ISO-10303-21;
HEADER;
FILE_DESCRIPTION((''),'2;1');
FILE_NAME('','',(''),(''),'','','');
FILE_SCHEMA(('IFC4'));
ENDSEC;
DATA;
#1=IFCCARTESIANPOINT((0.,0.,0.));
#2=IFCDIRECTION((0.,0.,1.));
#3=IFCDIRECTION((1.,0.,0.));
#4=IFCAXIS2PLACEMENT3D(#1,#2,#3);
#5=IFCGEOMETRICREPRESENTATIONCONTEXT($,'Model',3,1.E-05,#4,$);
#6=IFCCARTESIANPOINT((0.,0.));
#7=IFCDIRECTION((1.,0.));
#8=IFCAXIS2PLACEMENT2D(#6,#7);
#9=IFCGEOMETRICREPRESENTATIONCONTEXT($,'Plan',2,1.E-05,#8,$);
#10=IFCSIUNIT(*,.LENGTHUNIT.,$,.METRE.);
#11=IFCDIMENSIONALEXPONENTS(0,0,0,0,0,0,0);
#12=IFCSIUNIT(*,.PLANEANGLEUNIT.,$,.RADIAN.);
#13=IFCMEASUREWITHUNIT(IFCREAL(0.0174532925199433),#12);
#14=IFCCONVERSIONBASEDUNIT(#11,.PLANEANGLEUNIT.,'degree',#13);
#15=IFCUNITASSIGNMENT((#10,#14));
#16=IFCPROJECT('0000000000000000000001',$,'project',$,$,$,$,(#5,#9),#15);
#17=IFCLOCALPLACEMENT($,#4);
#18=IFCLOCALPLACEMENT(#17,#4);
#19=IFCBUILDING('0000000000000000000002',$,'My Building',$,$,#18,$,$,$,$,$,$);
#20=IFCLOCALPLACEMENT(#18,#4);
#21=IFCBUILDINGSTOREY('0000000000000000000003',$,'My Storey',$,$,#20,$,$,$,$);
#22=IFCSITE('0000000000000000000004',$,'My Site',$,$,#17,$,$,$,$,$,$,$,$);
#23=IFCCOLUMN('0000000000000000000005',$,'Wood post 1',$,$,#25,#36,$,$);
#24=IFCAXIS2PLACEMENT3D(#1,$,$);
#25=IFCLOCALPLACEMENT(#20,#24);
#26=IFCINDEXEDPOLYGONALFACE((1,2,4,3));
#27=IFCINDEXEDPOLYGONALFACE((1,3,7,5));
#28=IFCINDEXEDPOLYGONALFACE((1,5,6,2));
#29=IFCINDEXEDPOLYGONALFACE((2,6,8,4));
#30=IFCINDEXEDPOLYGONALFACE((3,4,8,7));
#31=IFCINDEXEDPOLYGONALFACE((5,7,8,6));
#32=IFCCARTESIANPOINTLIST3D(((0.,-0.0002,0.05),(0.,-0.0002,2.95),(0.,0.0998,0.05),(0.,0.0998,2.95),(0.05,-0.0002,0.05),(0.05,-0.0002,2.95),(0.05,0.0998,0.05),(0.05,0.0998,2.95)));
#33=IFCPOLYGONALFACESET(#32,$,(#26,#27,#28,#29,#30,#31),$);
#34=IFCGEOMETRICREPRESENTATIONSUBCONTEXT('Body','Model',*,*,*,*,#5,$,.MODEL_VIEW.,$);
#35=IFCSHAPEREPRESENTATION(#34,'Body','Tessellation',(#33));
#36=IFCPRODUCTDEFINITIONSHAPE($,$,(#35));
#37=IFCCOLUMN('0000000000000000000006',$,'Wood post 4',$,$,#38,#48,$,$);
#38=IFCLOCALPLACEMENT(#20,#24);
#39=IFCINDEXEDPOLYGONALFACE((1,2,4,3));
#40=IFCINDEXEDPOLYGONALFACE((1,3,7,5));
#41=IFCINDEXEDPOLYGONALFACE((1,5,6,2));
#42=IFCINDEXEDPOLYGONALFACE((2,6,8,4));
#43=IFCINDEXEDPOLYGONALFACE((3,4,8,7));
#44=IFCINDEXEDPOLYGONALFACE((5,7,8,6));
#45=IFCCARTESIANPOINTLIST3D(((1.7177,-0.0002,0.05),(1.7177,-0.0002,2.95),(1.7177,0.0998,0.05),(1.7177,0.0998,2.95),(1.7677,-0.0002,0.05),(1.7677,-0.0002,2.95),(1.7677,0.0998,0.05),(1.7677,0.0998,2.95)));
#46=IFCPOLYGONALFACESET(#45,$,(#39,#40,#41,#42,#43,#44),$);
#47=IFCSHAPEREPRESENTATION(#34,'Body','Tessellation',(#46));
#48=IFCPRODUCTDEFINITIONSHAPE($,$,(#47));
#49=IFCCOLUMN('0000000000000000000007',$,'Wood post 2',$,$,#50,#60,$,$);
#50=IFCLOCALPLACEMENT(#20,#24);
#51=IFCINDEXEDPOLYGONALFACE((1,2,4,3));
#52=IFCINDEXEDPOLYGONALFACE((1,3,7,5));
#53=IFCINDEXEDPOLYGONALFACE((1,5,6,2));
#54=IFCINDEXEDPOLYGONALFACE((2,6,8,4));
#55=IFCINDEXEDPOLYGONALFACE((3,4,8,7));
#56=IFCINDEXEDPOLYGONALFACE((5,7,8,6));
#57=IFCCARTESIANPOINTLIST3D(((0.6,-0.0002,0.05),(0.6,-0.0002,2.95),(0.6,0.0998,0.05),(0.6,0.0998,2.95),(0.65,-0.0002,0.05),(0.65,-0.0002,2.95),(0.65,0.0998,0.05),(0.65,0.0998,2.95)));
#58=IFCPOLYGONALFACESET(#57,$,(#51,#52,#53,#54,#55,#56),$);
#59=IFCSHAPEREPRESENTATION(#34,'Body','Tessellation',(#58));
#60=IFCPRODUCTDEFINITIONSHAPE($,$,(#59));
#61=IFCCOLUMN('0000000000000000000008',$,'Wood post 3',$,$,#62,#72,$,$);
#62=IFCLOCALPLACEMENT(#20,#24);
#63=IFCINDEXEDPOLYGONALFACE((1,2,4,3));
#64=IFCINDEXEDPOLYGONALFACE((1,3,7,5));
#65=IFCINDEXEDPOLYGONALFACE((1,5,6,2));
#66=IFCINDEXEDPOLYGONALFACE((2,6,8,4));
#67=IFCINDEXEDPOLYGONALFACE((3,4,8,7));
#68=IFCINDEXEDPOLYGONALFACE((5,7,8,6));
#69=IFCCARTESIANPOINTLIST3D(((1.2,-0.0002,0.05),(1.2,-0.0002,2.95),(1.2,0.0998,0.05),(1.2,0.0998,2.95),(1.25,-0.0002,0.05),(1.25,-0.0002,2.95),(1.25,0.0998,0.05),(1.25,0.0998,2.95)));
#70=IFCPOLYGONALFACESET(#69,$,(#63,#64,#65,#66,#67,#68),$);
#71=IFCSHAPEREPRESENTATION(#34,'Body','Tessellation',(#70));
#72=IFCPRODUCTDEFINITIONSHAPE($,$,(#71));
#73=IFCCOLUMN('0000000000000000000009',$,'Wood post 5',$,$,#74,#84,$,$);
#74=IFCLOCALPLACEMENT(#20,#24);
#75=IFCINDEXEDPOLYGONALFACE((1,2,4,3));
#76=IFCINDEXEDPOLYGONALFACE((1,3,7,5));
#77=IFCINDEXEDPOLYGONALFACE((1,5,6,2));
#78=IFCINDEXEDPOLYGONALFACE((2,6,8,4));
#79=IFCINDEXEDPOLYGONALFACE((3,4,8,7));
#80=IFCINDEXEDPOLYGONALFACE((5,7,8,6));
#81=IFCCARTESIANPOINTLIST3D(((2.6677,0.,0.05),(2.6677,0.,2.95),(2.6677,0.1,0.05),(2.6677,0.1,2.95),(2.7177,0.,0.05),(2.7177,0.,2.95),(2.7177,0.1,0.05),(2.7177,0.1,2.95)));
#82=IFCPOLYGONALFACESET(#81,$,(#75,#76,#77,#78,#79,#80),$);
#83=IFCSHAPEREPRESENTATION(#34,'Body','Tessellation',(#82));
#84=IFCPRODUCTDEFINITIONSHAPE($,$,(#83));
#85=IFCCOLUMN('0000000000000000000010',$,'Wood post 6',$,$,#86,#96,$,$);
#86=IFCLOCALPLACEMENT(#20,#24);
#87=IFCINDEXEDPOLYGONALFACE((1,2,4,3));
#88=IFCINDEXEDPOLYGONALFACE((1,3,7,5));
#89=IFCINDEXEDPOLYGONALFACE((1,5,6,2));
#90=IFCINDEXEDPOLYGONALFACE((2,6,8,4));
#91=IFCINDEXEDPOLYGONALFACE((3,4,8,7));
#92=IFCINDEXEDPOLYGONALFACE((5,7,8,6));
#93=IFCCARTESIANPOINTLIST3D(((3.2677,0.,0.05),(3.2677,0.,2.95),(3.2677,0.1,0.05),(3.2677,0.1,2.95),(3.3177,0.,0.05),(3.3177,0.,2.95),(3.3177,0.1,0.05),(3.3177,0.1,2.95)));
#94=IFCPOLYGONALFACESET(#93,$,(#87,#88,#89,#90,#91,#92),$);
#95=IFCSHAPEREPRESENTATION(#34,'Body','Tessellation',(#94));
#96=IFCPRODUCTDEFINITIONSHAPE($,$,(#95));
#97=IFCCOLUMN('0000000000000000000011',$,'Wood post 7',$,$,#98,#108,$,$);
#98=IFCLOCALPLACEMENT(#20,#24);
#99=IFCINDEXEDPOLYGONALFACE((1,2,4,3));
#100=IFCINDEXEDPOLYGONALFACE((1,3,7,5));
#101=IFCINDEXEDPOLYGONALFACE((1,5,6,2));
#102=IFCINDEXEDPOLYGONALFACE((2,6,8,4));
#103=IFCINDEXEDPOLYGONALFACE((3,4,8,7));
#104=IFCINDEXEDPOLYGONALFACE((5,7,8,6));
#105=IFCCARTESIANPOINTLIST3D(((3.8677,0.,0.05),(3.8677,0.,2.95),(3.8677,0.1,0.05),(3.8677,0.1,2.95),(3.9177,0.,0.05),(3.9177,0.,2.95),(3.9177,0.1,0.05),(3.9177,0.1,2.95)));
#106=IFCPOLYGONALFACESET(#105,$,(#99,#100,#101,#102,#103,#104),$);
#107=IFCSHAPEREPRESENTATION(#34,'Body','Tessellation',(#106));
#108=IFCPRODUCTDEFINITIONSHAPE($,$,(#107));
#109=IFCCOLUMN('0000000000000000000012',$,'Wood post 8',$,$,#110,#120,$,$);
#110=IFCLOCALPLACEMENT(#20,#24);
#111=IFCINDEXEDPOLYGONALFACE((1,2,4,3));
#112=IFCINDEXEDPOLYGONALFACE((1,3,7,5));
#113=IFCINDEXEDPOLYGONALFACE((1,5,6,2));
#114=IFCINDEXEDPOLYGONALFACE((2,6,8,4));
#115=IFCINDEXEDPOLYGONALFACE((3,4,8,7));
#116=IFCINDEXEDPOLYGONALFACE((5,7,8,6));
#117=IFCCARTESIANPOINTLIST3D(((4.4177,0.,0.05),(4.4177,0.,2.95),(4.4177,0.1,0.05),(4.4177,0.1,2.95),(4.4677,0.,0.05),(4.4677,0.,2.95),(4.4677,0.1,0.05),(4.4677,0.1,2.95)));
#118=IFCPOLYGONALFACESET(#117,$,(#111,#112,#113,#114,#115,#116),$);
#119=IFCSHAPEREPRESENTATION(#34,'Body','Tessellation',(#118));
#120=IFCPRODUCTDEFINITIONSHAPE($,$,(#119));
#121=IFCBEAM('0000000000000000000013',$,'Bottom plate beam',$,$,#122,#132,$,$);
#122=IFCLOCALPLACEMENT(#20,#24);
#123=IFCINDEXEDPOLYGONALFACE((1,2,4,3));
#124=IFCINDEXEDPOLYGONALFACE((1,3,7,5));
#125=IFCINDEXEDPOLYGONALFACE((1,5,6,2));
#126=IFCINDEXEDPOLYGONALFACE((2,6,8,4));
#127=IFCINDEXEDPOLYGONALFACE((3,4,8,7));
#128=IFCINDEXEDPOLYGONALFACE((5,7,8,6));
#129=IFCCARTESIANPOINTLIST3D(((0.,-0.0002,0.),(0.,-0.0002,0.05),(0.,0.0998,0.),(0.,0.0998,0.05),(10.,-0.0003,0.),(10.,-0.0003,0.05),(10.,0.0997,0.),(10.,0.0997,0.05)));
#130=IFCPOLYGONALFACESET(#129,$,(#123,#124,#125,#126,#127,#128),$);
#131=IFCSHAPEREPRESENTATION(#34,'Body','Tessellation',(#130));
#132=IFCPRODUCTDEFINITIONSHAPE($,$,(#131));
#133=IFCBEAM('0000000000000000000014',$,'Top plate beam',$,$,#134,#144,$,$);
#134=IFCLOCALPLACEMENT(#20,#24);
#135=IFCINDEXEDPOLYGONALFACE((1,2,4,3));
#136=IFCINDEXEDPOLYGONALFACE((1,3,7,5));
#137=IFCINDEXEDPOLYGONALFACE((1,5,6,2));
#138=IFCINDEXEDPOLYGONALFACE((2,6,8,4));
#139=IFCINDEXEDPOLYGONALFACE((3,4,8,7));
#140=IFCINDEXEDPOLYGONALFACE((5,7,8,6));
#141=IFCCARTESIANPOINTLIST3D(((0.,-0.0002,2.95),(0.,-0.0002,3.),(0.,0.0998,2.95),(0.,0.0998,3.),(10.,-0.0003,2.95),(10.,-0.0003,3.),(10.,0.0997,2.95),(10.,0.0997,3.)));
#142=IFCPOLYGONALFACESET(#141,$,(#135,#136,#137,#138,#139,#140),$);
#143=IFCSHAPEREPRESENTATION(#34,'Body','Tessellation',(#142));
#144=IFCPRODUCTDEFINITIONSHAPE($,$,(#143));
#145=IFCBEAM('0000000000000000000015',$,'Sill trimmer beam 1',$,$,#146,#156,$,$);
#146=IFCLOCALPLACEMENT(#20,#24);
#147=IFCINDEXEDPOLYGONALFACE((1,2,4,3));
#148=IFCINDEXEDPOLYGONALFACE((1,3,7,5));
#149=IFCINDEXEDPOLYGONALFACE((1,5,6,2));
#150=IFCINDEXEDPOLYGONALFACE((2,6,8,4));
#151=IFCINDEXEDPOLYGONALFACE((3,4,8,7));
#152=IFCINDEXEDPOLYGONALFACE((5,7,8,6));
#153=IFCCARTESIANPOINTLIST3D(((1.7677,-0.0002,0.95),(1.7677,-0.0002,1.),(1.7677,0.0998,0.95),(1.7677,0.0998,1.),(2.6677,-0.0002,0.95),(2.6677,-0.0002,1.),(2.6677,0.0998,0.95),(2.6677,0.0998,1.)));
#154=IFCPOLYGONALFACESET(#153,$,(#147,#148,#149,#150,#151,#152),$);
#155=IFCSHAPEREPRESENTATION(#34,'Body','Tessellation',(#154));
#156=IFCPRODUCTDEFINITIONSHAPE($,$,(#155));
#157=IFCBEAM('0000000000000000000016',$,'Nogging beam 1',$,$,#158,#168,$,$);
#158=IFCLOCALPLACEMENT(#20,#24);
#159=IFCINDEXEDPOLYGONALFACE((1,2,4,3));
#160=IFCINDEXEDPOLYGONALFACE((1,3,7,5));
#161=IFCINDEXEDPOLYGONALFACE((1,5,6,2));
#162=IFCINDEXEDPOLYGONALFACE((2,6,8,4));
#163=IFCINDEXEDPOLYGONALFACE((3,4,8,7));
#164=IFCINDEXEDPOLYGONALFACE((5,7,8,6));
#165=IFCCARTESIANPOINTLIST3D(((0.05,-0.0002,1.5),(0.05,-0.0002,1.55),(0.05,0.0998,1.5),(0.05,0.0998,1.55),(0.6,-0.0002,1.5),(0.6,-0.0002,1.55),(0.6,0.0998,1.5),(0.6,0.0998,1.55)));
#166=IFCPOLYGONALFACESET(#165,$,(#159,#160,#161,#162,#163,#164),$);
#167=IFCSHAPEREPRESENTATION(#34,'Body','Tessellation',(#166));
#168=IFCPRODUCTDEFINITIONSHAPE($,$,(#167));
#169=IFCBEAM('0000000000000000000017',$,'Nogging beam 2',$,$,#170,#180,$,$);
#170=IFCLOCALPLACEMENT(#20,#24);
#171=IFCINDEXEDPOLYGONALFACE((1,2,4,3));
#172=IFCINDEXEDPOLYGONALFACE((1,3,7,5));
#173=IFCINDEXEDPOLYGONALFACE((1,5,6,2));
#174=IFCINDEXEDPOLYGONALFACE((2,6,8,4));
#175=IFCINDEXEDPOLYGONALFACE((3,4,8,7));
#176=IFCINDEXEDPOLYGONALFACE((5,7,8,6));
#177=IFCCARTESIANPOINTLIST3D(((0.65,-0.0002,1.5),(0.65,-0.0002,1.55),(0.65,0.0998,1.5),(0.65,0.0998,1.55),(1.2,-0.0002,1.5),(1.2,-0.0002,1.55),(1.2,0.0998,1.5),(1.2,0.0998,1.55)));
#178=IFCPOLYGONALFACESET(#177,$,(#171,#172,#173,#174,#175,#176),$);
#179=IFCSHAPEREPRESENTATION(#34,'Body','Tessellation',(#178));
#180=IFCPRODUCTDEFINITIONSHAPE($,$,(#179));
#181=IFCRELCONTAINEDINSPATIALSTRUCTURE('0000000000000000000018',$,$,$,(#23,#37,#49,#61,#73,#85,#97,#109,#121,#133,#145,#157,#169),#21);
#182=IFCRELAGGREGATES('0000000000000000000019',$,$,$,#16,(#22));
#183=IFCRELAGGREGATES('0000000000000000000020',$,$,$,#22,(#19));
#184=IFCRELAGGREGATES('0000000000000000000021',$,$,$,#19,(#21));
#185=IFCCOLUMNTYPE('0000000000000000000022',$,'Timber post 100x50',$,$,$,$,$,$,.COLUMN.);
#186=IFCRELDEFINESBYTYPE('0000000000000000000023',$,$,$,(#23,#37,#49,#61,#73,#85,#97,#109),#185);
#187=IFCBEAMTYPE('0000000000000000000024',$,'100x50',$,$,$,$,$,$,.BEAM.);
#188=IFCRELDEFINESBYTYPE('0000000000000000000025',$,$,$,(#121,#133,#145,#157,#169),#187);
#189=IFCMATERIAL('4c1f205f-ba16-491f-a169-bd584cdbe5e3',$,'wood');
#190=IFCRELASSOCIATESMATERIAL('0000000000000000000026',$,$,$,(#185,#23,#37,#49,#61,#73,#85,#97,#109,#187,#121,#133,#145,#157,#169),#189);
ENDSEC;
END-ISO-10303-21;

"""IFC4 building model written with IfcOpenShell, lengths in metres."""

from ifc_helpers import new_model, entity, si_unit, converted_unit, frame, origin_with_axes, origin_2d_with_axis, place, context, subcontext, project, spatial, indexed_curve, outline, extrude, material, material_profile, profile_set, profile_usage, type_object, element, save


model = new_model("IFC4")

# Units and contexts
model_context = context("Model", 3, precision=1e-05, world=origin_with_axes())
plan_context = context("Plan", 2, precision=1e-05, world=origin_2d_with_axis())
body_context = subcontext(model_context, "Body", "Model", "MODEL_VIEW")
ifc_project = project(units=[si_unit("LENGTHUNIT", "METRE"), converted_unit("PLANEANGLEUNIT", "degree", entity("IfcReal", 0.0174532925199433), si_unit("PLANEANGLEUNIT", "RADIAN"), dimensions=[0, 0, 0, 0, 0, 0, 0])], contexts=[model_context, plan_context])

# Site, building, storey
site_placement = place(None, origin_with_axes())
site = spatial("IfcSite", under=ifc_project, at=site_placement, Name="My Site")
building_placement = place(site_placement, origin_with_axes())
building = spatial("IfcBuilding", under=site, at=building_placement, Name="My Building")
storey_placement = place(building_placement, origin_with_axes())
storey = spatial("IfcBuildingStorey", under=building, at=storey_placement, Name="My Storey")

# Columns
ifc_material_1 = material(Name="4c1f205f-ba16-491f-a169-bd584cdbe5e3", Category="wood")
ifc_material_profile_1 = material_profile(ifc_material_1, outline(indexed_curve([(-0.05, 0.025), (0.05, 0.025), (0.05, -0.025), (-0.05, -0.025), (-0.05, 0.025)])))
ifc_profile_set_1 = profile_set([ifc_material_profile_1])
ifc_profile_usage_1 = profile_usage(ifc_profile_set_1, cardinal=5)
column_type = type_object("IfcColumnType", Name="Timber post 100x50", PredefinedType="COLUMN", material=ifc_profile_set_1)
column_1_placement = place(storey_placement, frame((0.025, 0.0498, 0.05), z_axis=(0.0, 0.0, 1.0), x_axis=(0.0, 1.0, 0.0)))
element("IfcColumn", 1, at=column_1_placement, inside=storey, type_object=column_type, material=ifc_profile_usage_1, Name="Wood post 1", context=body_context, shape_type="SweptSolid", body=[
    extrude(outline(indexed_curve([(-0.05, 0.025), (0.05, 0.025), (0.05, -0.025), (-0.05, -0.025), (-0.05, 0.025)])), origin_with_axes(), (0.0, 0.0, 1.0), 2.9),
])
ifc_profile_usage_2 = profile_usage(ifc_profile_set_1, cardinal=5)
column_2_placement = place(storey_placement, frame((1.7427, 0.0498, 0.05), z_axis=(0.0, 0.0, 1.0), x_axis=(0.0, 1.0, 0.0)))
element("IfcColumn", 2, at=column_2_placement, inside=storey, type_object=column_type, material=ifc_profile_usage_2, Name="Wood post 4", context=body_context, shape_type="SweptSolid", body=[
    extrude(outline(indexed_curve([(-0.05, 0.025), (0.05, 0.025), (0.05, -0.025), (-0.05, -0.025), (-0.05, 0.025)])), origin_with_axes(), (0.0, 0.0, 1.0), 2.9),
])
ifc_profile_usage_3 = profile_usage(ifc_profile_set_1, cardinal=5)
column_3_placement = place(storey_placement, frame((0.625, 0.0498, 0.05), z_axis=(0.0, 0.0, 1.0), x_axis=(0.0, 1.0, 0.0)))
element("IfcColumn", 3, at=column_3_placement, inside=storey, type_object=column_type, material=ifc_profile_usage_3, Name="Wood post 2", context=body_context, shape_type="SweptSolid", body=[
    extrude(outline(indexed_curve([(-0.05, 0.025), (0.05, 0.025), (0.05, -0.025), (-0.05, -0.025), (-0.05, 0.025)])), origin_with_axes(), (0.0, 0.0, 1.0), 2.9),
])
ifc_profile_usage_4 = profile_usage(ifc_profile_set_1, cardinal=5)
column_4_placement = place(storey_placement, frame((1.225, 0.0498, 0.05), z_axis=(0.0, 0.0, 1.0), x_axis=(0.0, 1.0, 0.0)))
element("IfcColumn", 4, at=column_4_placement, inside=storey, type_object=column_type, material=ifc_profile_usage_4, Name="Wood post 3", context=body_context, shape_type="SweptSolid", body=[
    extrude(outline(indexed_curve([(-0.05, 0.025), (0.05, 0.025), (0.05, -0.025), (-0.05, -0.025), (-0.05, 0.025)])), origin_with_axes(), (0.0, 0.0, 1.0), 2.9),
])
ifc_profile_usage_5 = profile_usage(ifc_profile_set_1, cardinal=5)
column_5_placement = place(storey_placement, frame((2.6927, 0.05, 0.05), z_axis=(0.0, 0.0, 1.0), x_axis=(0.0, 1.0, 0.0)))
element("IfcColumn", 5, at=column_5_placement, inside=storey, type_object=column_type, material=ifc_profile_usage_5, Name="Wood post 5", context=body_context, shape_type="SweptSolid", body=[
    extrude(outline(indexed_curve([(-0.05, 0.025), (0.05, 0.025), (0.05, -0.025), (-0.05, -0.025), (-0.05, 0.025)])), origin_with_axes(), (0.0, 0.0, 1.0), 2.9),
])
ifc_profile_usage_6 = profile_usage(ifc_profile_set_1, cardinal=5)
column_6_placement = place(storey_placement, frame((3.2927, 0.05, 0.05), z_axis=(0.0, 0.0, 1.0), x_axis=(0.0, 1.0, 0.0)))
element("IfcColumn", 6, at=column_6_placement, inside=storey, type_object=column_type, material=ifc_profile_usage_6, Name="Wood post 6", context=body_context, shape_type="SweptSolid", body=[
    extrude(outline(indexed_curve([(-0.05, 0.025), (0.05, 0.025), (0.05, -0.025), (-0.05, -0.025), (-0.05, 0.025)])), origin_with_axes(), (0.0, 0.0, 1.0), 2.9),
])
ifc_profile_usage_7 = profile_usage(ifc_profile_set_1, cardinal=5)
column_7_placement = place(storey_placement, frame((3.8927, 0.05, 0.05), z_axis=(0.0, 0.0, 1.0), x_axis=(0.0, 1.0, 0.0)))
element("IfcColumn", 7, at=column_7_placement, inside=storey, type_object=column_type, material=ifc_profile_usage_7, Name="Wood post 7", context=body_context, shape_type="SweptSolid", body=[
    extrude(outline(indexed_curve([(-0.05, 0.025), (0.05, 0.025), (0.05, -0.025), (-0.05, -0.025), (-0.05, 0.025)])), origin_with_axes(), (0.0, 0.0, 1.0), 2.9),
])
ifc_profile_usage_8 = profile_usage(ifc_profile_set_1, cardinal=5)
column_8_placement = place(storey_placement, frame((4.4427, 0.05, 0.05), z_axis=(0.0, 0.0, 1.0), x_axis=(0.0, 1.0, 0.0)))
element("IfcColumn", 8, at=column_8_placement, inside=storey, type_object=column_type, material=ifc_profile_usage_8, Name="Wood post 8", context=body_context, shape_type="SweptSolid", body=[
    extrude(outline(indexed_curve([(-0.05, 0.025), (0.05, 0.025), (0.05, -0.025), (-0.05, -0.025), (-0.05, 0.025)])), origin_with_axes(), (0.0, 0.0, 1.0), 2.9),
])

# Beams
ifc_material_profile_2 = material_profile(ifc_material_1, outline(indexed_curve([(-0.05, 0.025), (0.05, 0.025), (0.05, -0.025), (-0.05, -0.025), (-0.05, 0.025)])))
ifc_profile_set_2 = profile_set([ifc_material_profile_2])
ifc_profile_usage_9 = profile_usage(ifc_profile_set_2, cardinal=5)
beam_type_1 = type_object("IfcBeamType", Name="100x50", PredefinedType="BEAM", material=ifc_profile_set_2)
beam_1_placement = place(storey_placement, frame((0.0, 0.0498, 0.025), z_axis=(1.0, -0.000001, 0.000001), x_axis=(0.000001, 1.0, 0.0)))
element("IfcBeam", 9, at=beam_1_placement, inside=storey, type_object=beam_type_1, material=ifc_profile_usage_9, Name="Bottom plate beam", context=body_context, shape_type="SweptSolid", body=[
    extrude(outline(indexed_curve([(-0.05, 0.025), (0.05, 0.025), (0.05, -0.025), (-0.05, -0.025), (-0.05, 0.025)])), origin_with_axes(), (0.0, 0.0, 1.0), 10.0),
])
ifc_profile_usage_10 = profile_usage(ifc_profile_set_2, cardinal=5)
beam_2_placement = place(storey_placement, frame((0.0, 0.0498, 2.975), z_axis=(1.0, -0.000001, 0.000001), x_axis=(0.000001, 1.0, 0.0)))
element("IfcBeam", 10, at=beam_2_placement, inside=storey, type_object=beam_type_1, material=ifc_profile_usage_10, Name="Top plate beam", context=body_context, shape_type="SweptSolid", body=[
    extrude(outline(indexed_curve([(-0.05, 0.025), (0.05, 0.025), (0.05, -0.025), (-0.05, -0.025), (-0.05, 0.025)])), origin_with_axes(), (0.0, 0.0, 1.0), 10.0),
])
ifc_profile_usage_11 = profile_usage(ifc_profile_set_2, cardinal=5)
beam_3_placement = place(storey_placement, frame((1.7677, 0.0498, 0.975), z_axis=(1.0, -0.000001, 0.000001), x_axis=(0.000001, 1.0, 0.0)))
element("IfcBeam", 11, at=beam_3_placement, inside=storey, type_object=beam_type_1, material=ifc_profile_usage_11, Name="Sill trimmer beam 1", context=body_context, shape_type="SweptSolid", body=[
    extrude(outline(indexed_curve([(-0.05, 0.025), (0.05, 0.025), (0.05, -0.025), (-0.05, -0.025), (-0.05, 0.025)])), origin_with_axes(), (0.0, 0.0, 1.0), 0.9),
])
ifc_profile_usage_12 = profile_usage(ifc_profile_set_2, cardinal=5)
beam_4_placement = place(storey_placement, frame((0.05, 0.0498, 1.525), z_axis=(1.0, -0.000001, 0.000001), x_axis=(0.000001, 1.0, 0.0)))
element("IfcBeam", 12, at=beam_4_placement, inside=storey, type_object=beam_type_1, material=ifc_profile_usage_12, Name="Nogging beam 1", context=body_context, shape_type="SweptSolid", body=[
    extrude(outline(indexed_curve([(-0.05, 0.025), (0.05, 0.025), (0.05, -0.025), (-0.05, -0.025), (-0.05, 0.025)])), origin_with_axes(), (0.0, 0.0, 1.0), 0.55),
])
ifc_profile_usage_13 = profile_usage(ifc_profile_set_2, cardinal=5)
beam_5_placement = place(storey_placement, frame((0.65, 0.0498, 1.525), z_axis=(1.0, -0.000001, 0.000001), x_axis=(0.000001, 1.0, 0.0)))
element("IfcBeam", 13, at=beam_5_placement, inside=storey, type_object=beam_type_1, material=ifc_profile_usage_13, Name="Nogging beam 2", context=body_context, shape_type="SweptSolid", body=[
    extrude(outline(indexed_curve([(-0.05, 0.025), (0.05, 0.025), (0.05, -0.025), (-0.05, -0.025), (-0.05, 0.025)])), origin_with_axes(), (0.0, 0.0, 1.0), 0.55),
])

save(model, "model.ifc")
